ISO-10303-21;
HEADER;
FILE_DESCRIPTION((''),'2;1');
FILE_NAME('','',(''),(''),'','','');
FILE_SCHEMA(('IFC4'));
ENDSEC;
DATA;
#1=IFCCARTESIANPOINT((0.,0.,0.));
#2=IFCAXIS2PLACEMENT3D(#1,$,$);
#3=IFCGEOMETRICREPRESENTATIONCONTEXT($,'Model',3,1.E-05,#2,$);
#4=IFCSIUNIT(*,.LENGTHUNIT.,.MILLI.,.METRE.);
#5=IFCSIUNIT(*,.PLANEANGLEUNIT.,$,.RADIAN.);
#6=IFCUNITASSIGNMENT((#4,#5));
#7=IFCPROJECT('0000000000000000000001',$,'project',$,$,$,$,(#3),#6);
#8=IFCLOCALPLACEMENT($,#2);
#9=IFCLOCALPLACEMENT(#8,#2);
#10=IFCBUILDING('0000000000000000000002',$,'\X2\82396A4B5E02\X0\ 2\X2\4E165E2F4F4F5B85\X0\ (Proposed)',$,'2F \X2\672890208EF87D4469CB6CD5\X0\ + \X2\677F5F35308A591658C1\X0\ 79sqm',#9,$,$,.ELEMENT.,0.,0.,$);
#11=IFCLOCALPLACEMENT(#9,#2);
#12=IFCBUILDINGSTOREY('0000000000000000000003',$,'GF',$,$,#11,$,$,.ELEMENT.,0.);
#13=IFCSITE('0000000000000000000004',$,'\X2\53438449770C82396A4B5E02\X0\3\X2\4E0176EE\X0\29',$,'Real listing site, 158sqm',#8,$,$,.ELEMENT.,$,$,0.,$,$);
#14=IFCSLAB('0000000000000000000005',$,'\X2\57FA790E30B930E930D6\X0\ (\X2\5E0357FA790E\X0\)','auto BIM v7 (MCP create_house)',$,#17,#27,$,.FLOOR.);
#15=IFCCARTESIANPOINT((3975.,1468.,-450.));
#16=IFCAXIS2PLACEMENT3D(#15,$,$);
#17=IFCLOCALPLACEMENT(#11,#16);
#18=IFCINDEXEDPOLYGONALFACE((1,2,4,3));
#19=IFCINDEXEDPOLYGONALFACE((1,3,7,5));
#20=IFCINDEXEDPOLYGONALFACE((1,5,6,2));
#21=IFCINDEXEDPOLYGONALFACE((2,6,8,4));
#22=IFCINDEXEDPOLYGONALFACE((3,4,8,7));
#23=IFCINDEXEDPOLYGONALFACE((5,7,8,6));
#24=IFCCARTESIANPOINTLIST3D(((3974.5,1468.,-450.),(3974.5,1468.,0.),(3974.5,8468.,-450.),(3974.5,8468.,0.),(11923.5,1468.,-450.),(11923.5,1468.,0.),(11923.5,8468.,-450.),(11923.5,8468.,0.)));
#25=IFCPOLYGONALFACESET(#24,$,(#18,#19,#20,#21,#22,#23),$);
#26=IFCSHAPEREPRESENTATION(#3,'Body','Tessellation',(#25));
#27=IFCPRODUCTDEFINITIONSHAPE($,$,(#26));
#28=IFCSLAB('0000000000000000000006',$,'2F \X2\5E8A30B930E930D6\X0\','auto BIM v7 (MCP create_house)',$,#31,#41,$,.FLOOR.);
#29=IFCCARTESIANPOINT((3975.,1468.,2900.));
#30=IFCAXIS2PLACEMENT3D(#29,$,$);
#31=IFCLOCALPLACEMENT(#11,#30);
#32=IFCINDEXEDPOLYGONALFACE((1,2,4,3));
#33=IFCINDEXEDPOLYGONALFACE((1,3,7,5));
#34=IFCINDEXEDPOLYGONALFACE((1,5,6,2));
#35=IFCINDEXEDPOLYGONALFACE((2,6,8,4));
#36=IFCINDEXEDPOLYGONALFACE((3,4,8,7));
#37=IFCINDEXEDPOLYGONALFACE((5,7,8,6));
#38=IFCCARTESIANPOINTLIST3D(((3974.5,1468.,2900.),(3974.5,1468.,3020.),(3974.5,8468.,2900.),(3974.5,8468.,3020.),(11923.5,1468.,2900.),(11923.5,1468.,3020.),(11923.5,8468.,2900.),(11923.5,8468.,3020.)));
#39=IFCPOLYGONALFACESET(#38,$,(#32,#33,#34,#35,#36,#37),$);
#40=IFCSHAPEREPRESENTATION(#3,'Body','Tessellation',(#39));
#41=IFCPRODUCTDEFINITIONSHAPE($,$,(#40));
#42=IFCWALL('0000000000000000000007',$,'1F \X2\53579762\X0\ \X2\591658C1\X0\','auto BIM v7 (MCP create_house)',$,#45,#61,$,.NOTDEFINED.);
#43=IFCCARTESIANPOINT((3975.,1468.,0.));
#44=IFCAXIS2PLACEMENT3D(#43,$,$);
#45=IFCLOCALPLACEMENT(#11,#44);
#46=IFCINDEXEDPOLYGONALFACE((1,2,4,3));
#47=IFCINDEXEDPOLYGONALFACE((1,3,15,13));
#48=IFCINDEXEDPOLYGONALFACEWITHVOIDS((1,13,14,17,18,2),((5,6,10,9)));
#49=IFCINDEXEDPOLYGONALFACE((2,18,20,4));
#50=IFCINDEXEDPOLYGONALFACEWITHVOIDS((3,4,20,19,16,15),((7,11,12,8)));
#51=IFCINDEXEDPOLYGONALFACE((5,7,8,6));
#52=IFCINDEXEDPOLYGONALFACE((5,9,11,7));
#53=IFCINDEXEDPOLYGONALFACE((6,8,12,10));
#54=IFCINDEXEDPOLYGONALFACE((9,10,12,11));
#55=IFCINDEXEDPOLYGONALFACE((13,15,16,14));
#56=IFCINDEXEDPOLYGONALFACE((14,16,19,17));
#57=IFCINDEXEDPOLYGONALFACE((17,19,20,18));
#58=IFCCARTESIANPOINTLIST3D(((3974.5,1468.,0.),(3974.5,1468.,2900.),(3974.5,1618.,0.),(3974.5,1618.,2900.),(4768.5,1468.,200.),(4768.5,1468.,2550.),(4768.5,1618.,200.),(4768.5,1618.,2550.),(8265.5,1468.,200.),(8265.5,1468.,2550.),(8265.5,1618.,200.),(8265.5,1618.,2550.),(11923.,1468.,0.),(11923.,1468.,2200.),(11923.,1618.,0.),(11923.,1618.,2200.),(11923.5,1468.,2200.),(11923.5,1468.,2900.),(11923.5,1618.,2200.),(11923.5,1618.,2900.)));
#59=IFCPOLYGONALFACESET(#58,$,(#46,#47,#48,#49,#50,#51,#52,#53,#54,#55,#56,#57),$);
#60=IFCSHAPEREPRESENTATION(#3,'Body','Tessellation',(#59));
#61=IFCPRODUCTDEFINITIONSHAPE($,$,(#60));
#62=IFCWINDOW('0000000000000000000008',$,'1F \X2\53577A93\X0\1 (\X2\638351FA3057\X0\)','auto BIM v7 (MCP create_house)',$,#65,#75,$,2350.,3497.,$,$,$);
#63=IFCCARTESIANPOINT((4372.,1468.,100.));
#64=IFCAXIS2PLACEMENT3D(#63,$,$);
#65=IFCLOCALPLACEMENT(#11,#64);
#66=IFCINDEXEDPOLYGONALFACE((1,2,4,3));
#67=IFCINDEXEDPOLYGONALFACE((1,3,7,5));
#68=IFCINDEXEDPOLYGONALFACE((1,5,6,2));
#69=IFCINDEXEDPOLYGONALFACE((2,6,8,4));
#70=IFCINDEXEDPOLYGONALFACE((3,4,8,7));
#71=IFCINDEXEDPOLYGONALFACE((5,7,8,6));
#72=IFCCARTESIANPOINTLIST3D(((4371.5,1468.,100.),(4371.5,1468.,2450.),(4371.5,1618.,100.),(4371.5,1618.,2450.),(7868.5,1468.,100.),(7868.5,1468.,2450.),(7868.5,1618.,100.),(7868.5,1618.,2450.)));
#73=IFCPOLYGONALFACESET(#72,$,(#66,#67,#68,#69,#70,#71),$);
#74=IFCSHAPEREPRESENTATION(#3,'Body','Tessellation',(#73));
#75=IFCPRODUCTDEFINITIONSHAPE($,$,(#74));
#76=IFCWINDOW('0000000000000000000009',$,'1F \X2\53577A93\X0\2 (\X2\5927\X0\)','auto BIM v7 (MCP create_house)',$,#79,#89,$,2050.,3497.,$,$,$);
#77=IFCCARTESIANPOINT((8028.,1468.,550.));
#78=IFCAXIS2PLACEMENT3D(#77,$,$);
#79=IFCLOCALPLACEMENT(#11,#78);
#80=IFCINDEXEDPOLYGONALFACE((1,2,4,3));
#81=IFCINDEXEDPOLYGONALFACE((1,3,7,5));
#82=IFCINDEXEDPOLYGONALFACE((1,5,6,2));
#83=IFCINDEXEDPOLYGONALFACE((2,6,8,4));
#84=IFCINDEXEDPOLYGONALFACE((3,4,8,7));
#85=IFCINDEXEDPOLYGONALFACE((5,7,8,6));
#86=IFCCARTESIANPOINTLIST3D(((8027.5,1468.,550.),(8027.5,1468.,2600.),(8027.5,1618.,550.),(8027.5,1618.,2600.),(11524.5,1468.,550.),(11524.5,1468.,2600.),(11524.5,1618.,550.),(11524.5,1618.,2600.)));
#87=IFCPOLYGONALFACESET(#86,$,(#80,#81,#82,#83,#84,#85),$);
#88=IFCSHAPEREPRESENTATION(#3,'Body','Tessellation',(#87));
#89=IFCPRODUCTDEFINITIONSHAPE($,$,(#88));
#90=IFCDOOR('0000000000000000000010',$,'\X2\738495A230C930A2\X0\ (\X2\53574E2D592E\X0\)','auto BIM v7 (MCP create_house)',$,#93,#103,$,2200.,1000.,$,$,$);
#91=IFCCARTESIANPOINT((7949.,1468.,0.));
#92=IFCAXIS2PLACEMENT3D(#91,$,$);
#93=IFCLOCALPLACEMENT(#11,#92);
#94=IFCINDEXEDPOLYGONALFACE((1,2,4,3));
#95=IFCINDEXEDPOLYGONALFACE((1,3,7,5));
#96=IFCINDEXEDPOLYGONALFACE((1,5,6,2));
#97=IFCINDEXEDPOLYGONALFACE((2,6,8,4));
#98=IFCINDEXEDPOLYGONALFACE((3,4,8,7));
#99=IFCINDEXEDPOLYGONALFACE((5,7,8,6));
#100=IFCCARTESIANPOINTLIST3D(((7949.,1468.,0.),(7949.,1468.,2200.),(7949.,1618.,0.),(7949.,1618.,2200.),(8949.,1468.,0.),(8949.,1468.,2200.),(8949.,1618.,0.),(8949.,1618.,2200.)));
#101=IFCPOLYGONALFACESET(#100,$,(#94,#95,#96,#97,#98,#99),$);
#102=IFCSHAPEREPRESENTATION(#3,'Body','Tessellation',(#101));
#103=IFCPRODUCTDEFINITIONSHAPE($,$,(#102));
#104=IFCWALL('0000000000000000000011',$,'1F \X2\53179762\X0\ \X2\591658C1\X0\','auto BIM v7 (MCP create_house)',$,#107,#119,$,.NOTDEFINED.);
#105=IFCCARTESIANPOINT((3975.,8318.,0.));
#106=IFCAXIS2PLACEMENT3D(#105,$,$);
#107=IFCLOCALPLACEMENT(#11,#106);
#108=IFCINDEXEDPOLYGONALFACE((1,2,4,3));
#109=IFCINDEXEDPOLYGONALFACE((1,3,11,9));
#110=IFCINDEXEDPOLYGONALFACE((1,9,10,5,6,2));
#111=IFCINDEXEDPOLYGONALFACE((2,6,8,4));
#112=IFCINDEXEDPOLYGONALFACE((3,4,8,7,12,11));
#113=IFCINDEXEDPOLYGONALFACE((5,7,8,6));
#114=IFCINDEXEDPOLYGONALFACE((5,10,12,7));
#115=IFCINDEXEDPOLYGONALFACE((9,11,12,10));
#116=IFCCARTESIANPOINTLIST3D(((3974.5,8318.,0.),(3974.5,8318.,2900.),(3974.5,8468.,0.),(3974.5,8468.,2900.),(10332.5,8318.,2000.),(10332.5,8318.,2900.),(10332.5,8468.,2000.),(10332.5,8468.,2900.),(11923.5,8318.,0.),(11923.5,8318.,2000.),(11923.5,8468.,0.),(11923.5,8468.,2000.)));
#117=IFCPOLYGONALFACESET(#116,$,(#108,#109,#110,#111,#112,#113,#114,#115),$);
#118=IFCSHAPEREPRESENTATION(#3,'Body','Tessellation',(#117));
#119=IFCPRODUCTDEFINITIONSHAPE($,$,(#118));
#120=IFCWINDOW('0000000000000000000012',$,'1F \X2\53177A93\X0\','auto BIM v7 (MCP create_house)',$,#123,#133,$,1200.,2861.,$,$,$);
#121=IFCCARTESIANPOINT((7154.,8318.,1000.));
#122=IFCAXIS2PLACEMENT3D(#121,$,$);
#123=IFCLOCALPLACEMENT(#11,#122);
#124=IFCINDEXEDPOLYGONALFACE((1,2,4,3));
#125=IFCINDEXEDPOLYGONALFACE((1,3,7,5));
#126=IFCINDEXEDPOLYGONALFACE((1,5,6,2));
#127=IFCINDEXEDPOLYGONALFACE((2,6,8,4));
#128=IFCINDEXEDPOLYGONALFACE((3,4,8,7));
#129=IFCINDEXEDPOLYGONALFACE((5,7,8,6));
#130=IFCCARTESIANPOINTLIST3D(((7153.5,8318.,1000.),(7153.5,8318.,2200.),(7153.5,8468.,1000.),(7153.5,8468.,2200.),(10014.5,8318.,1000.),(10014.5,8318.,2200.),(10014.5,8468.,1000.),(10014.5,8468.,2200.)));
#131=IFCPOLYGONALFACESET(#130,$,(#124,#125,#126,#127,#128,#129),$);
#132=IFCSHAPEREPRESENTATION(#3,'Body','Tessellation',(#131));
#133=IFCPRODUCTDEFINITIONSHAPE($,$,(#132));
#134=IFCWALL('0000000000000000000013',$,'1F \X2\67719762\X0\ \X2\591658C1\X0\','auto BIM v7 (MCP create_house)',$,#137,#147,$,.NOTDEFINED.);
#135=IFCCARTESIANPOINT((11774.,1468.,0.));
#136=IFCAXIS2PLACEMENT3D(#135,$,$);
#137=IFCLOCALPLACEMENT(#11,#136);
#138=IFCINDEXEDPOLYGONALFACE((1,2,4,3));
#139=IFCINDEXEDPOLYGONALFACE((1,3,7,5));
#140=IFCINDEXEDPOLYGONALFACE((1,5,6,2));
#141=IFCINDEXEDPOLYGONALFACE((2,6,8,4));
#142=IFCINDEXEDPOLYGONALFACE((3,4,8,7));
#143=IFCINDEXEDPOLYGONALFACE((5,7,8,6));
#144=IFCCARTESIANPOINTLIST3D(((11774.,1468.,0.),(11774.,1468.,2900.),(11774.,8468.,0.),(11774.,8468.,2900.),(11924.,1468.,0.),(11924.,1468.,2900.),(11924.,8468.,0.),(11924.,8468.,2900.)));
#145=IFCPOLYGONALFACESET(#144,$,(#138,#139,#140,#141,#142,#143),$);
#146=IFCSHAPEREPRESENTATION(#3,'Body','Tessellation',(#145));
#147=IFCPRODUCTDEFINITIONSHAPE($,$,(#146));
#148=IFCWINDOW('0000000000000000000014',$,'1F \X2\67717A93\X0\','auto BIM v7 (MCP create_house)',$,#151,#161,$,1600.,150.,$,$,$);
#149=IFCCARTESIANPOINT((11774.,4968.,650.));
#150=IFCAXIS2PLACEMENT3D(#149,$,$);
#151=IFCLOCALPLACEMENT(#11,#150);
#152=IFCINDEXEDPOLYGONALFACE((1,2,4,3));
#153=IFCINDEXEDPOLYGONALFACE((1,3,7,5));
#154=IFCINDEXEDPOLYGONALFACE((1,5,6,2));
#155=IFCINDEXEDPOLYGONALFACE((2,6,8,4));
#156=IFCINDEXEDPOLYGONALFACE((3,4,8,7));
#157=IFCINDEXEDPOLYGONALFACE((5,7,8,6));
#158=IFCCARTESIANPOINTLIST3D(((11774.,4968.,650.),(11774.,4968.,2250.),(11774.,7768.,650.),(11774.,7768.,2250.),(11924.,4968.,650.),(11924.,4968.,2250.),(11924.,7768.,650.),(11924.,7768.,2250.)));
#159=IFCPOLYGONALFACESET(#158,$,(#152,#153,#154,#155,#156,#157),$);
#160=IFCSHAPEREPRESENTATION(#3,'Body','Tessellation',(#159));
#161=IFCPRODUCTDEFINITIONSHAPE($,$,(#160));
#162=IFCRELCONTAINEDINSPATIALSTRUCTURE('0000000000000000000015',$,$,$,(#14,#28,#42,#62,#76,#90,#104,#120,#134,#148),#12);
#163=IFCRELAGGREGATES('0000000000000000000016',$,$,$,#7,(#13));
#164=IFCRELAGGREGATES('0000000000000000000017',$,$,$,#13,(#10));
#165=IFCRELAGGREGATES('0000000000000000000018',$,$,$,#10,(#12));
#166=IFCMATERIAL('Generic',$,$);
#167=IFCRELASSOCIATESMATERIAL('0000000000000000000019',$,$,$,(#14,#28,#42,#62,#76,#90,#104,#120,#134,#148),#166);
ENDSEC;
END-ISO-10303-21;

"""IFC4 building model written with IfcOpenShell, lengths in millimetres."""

from ifc_helpers import new_model, si_unit, frame, frame_2d, origin, place, context, project, spatial, rectangle, extrude, material, element, fill, save


model = new_model("IFC4")

# Units and contexts
model_context = context("Model", 3, precision=1e-05, world=origin())
ifc_project = project(units=[si_unit("LENGTHUNIT", "METRE", prefix="MILLI"), si_unit("PLANEANGLEUNIT", "RADIAN")], contexts=[model_context])

# Site, building, storey
site_placement = place(None, origin())
site = spatial("IfcSite", under=ifc_project, at=site_placement, Name="千葉県船橋市3丁目29", ObjectType="Real listing site, 158sqm", CompositionType="ELEMENT", RefElevation=0.0)
building_placement = place(site_placement, origin())
building = spatial("IfcBuilding", under=site, at=building_placement, Name="船橋市 2世帯住宅 (Proposed)", ObjectType="2F 木造軸組構法 + 板張り外壁 79sqm", CompositionType="ELEMENT", ElevationOfRefHeight=0.0, ElevationOfTerrain=0.0)
storey_placement = place(building_placement, origin())
storey = spatial("IfcBuildingStorey", under=building, at=storey_placement, Name="GF", CompositionType="ELEMENT", Elevation=0.0)

# Slabs
ifc_material = material(Name="Generic")
slab_1_placement = place(storey_placement, frame((3975.0, 1468.0, -450.0)))
element("IfcSlab", 1, at=slab_1_placement, inside=storey, material=ifc_material, Name="基礎スラブ (布基礎)", Description="auto BIM v7 (MCP create_house)", PredefinedType="FLOOR", context=model_context, shape_type="SweptSolid", body=[
    extrude(rectangle(XDim=7949.0, YDim=7000.0, at=frame_2d((3974.0, 3500.0))), frame((3975.0, 1468.0, -450.0)), (0.0, 0.0, 1.0), 450.0),
])
slab_2_placement = place(storey_placement, frame((3975.0, 1468.0, 2900.0)))
element("IfcSlab", 2, at=slab_2_placement, inside=storey, material=ifc_material, Name="2F 床スラブ", Description="auto BIM v7 (MCP create_house)", PredefinedType="FLOOR", context=model_context, shape_type="SweptSolid", body=[
    extrude(rectangle(XDim=7949.0, YDim=7000.0, at=frame_2d((3974.0, 3500.0))), frame((3975.0, 1468.0, 2900.0)), (0.0, 0.0, 1.0), 120.0),
])

# Wall, openings, windows, door
wall_1_placement = place(storey_placement, frame((3975.0, 1468.0, 0.0)))
wall_1 = element("IfcWall", 3, at=wall_1_placement, inside=storey, material=ifc_material, Name="1F 南面 外壁", Description="auto BIM v7 (MCP create_house)", PredefinedType="NOTDEFINED", context=model_context, shape_type="SweptSolid", body=[
    extrude(rectangle(XDim=7949.0, YDim=150.0, at=frame_2d((3974.0, 75.0))), frame((3975.0, 1468.0, 0.0)), (0.0, 0.0, 1.0), 2900.0),
])
opening_1_placement = place(storey_placement, frame((4372.0, 1468.0, 100.0)))
opening_1 = element("IfcOpeningElement", 4, at=opening_1_placement, cuts=wall_1, PredefinedType="NOTDEFINED", context=model_context, shape_type="SweptSolid", body=[
    extrude(rectangle(XDim=3497.0, YDim=150.0, at=frame_2d((1748.0, 75.0))), frame((4372.0, 1468.0, 100.0)), (0.0, 0.0, 1.0), 2350.0),
])
opening_2_placement = place(storey_placement, frame((8028.0, 1468.0, 550.0)))
opening_2 = element("IfcOpeningElement", 5, at=opening_2_placement, cuts=wall_1, PredefinedType="NOTDEFINED", context=model_context, shape_type="SweptSolid", body=[
    extrude(rectangle(XDim=3497.0, YDim=150.0, at=frame_2d((1748.0, 75.0))), frame((8028.0, 1468.0, 550.0)), (0.0, 0.0, 1.0), 2050.0),
])
opening_3_placement = place(storey_placement, frame((7949.0, 1468.0, 0.0)))
opening_3 = element("IfcOpeningElement", 6, at=opening_3_placement, cuts=wall_1, PredefinedType="NOTDEFINED", context=model_context, shape_type="SweptSolid", body=[
    extrude(rectangle(XDim=1000.0, YDim=150.0, at=frame_2d((500.0, 75.0))), frame((7949.0, 1468.0, 0.0)), (0.0, 0.0, 1.0), 2200.0),
])
window_1_placement = place(storey_placement, frame((4372.0, 1468.0, 100.0)))
window_1 = element("IfcWindow", 7, at=window_1_placement, inside=storey, material=ifc_material, Name="1F 南窓1 (掃出し)", Description="auto BIM v7 (MCP create_house)", OverallHeight=2350.0, OverallWidth=3497.0, context=model_context, shape_type="SweptSolid", body=[
    extrude(rectangle(XDim=3497.0, YDim=150.0, at=frame_2d((1748.0, 75.0))), frame((4372.0, 1468.0, 100.0)), (0.0, 0.0, 1.0), 2350.0),
])
fill(opening_1, window_1)
window_2_placement = place(storey_placement, frame((8028.0, 1468.0, 550.0)))
window_2 = element("IfcWindow", 8, at=window_2_placement, inside=storey, material=ifc_material, Name="1F 南窓2 (大)", Description="auto BIM v7 (MCP create_house)", OverallHeight=2050.0, OverallWidth=3497.0, context=model_context, shape_type="SweptSolid", body=[
    extrude(rectangle(XDim=3497.0, YDim=150.0, at=frame_2d((1748.0, 75.0))), frame((8028.0, 1468.0, 550.0)), (0.0, 0.0, 1.0), 2050.0),
])
fill(opening_2, window_2)
door_placement = place(storey_placement, frame((7949.0, 1468.0, 0.0)))
door = element("IfcDoor", 9, at=door_placement, inside=storey, material=ifc_material, Name="玄関ドア (南中央)", Description="auto BIM v7 (MCP create_house)", OverallHeight=2200.0, OverallWidth=1000.0, context=model_context, shape_type="SweptSolid", body=[
    extrude(rectangle(XDim=1000.0, YDim=150.0, at=frame_2d((500.0, 75.0))), frame((7949.0, 1468.0, 0.0)), (0.0, 0.0, 1.0), 2200.0),
])
fill(opening_3, door)

# Walls, openings, windows
wall_2_placement = place(storey_placement, frame((3975.0, 8318.0, 0.0)))
wall_2 = element("IfcWall", 10, at=wall_2_placement, inside=storey, material=ifc_material, Name="1F 北面 外壁", Description="auto BIM v7 (MCP create_house)", PredefinedType="NOTDEFINED", context=model_context, shape_type="SweptSolid", body=[
    extrude(rectangle(XDim=7949.0, YDim=150.0, at=frame_2d((3974.0, 75.0))), frame((3975.0, 8318.0, 0.0)), (0.0, 0.0, 1.0), 2900.0),
])
opening_4_placement = place(storey_placement, frame((7154.0, 8318.0, 1000.0)))
opening_4 = element("IfcOpeningElement", 11, at=opening_4_placement, cuts=wall_2, PredefinedType="NOTDEFINED", context=model_context, shape_type="SweptSolid", body=[
    extrude(rectangle(XDim=2861.0, YDim=150.0, at=frame_2d((1430.0, 75.0))), frame((7154.0, 8318.0, 1000.0)), (0.0, 0.0, 1.0), 1200.0),
])
window_3_placement = place(storey_placement, frame((7154.0, 8318.0, 1000.0)))
window_3 = element("IfcWindow", 12, at=window_3_placement, inside=storey, material=ifc_material, Name="1F 北窓", Description="auto BIM v7 (MCP create_house)", OverallHeight=1200.0, OverallWidth=2861.0, context=model_context, shape_type="SweptSolid", body=[
    extrude(rectangle(XDim=2861.0, YDim=150.0, at=frame_2d((1430.0, 75.0))), frame((7154.0, 8318.0, 1000.0)), (0.0, 0.0, 1.0), 1200.0),
])
fill(opening_4, window_3)
wall_3_placement = place(storey_placement, frame((11774.0, 1468.0, 0.0)))
wall_3 = element("IfcWall", 13, at=wall_3_placement, inside=storey, material=ifc_material, Name="1F 東面 外壁", Description="auto BIM v7 (MCP create_house)", PredefinedType="NOTDEFINED", context=model_context, shape_type="SweptSolid", body=[
    extrude(rectangle(XDim=150.0, YDim=7000.0, at=frame_2d((75.0, 3500.0))), frame((11774.0, 1468.0, 0.0)), (0.0, 0.0, 1.0), 2900.0),
])
opening_5_placement = place(storey_placement, frame((11774.0, 4968.0, 650.0)))
opening_5 = element("IfcOpeningElement", 14, at=opening_5_placement, cuts=wall_3, PredefinedType="NOTDEFINED", context=model_context, shape_type="SweptSolid", body=[
    extrude(rectangle(XDim=150.0, YDim=2800.0, at=frame_2d((75.0, 1400.0))), frame((11774.0, 4968.0, 650.0)), (0.0, 0.0, 1.0), 1600.0),
])
window_4_placement = place(storey_placement, frame((11774.0, 4968.0, 650.0)))
window_4 = element("IfcWindow", 15, at=window_4_placement, inside=storey, material=ifc_material, Name="1F 東窓", Description="auto BIM v7 (MCP create_house)", OverallHeight=1600.0, OverallWidth=150.0, context=model_context, shape_type="SweptSolid", body=[
    extrude(rectangle(XDim=150.0, YDim=2800.0, at=frame_2d((75.0, 1400.0))), frame((11774.0, 4968.0, 650.0)), (0.0, 0.0, 1.0), 1600.0),
])
fill(opening_5, window_4)

save(model, "model.ifc")
